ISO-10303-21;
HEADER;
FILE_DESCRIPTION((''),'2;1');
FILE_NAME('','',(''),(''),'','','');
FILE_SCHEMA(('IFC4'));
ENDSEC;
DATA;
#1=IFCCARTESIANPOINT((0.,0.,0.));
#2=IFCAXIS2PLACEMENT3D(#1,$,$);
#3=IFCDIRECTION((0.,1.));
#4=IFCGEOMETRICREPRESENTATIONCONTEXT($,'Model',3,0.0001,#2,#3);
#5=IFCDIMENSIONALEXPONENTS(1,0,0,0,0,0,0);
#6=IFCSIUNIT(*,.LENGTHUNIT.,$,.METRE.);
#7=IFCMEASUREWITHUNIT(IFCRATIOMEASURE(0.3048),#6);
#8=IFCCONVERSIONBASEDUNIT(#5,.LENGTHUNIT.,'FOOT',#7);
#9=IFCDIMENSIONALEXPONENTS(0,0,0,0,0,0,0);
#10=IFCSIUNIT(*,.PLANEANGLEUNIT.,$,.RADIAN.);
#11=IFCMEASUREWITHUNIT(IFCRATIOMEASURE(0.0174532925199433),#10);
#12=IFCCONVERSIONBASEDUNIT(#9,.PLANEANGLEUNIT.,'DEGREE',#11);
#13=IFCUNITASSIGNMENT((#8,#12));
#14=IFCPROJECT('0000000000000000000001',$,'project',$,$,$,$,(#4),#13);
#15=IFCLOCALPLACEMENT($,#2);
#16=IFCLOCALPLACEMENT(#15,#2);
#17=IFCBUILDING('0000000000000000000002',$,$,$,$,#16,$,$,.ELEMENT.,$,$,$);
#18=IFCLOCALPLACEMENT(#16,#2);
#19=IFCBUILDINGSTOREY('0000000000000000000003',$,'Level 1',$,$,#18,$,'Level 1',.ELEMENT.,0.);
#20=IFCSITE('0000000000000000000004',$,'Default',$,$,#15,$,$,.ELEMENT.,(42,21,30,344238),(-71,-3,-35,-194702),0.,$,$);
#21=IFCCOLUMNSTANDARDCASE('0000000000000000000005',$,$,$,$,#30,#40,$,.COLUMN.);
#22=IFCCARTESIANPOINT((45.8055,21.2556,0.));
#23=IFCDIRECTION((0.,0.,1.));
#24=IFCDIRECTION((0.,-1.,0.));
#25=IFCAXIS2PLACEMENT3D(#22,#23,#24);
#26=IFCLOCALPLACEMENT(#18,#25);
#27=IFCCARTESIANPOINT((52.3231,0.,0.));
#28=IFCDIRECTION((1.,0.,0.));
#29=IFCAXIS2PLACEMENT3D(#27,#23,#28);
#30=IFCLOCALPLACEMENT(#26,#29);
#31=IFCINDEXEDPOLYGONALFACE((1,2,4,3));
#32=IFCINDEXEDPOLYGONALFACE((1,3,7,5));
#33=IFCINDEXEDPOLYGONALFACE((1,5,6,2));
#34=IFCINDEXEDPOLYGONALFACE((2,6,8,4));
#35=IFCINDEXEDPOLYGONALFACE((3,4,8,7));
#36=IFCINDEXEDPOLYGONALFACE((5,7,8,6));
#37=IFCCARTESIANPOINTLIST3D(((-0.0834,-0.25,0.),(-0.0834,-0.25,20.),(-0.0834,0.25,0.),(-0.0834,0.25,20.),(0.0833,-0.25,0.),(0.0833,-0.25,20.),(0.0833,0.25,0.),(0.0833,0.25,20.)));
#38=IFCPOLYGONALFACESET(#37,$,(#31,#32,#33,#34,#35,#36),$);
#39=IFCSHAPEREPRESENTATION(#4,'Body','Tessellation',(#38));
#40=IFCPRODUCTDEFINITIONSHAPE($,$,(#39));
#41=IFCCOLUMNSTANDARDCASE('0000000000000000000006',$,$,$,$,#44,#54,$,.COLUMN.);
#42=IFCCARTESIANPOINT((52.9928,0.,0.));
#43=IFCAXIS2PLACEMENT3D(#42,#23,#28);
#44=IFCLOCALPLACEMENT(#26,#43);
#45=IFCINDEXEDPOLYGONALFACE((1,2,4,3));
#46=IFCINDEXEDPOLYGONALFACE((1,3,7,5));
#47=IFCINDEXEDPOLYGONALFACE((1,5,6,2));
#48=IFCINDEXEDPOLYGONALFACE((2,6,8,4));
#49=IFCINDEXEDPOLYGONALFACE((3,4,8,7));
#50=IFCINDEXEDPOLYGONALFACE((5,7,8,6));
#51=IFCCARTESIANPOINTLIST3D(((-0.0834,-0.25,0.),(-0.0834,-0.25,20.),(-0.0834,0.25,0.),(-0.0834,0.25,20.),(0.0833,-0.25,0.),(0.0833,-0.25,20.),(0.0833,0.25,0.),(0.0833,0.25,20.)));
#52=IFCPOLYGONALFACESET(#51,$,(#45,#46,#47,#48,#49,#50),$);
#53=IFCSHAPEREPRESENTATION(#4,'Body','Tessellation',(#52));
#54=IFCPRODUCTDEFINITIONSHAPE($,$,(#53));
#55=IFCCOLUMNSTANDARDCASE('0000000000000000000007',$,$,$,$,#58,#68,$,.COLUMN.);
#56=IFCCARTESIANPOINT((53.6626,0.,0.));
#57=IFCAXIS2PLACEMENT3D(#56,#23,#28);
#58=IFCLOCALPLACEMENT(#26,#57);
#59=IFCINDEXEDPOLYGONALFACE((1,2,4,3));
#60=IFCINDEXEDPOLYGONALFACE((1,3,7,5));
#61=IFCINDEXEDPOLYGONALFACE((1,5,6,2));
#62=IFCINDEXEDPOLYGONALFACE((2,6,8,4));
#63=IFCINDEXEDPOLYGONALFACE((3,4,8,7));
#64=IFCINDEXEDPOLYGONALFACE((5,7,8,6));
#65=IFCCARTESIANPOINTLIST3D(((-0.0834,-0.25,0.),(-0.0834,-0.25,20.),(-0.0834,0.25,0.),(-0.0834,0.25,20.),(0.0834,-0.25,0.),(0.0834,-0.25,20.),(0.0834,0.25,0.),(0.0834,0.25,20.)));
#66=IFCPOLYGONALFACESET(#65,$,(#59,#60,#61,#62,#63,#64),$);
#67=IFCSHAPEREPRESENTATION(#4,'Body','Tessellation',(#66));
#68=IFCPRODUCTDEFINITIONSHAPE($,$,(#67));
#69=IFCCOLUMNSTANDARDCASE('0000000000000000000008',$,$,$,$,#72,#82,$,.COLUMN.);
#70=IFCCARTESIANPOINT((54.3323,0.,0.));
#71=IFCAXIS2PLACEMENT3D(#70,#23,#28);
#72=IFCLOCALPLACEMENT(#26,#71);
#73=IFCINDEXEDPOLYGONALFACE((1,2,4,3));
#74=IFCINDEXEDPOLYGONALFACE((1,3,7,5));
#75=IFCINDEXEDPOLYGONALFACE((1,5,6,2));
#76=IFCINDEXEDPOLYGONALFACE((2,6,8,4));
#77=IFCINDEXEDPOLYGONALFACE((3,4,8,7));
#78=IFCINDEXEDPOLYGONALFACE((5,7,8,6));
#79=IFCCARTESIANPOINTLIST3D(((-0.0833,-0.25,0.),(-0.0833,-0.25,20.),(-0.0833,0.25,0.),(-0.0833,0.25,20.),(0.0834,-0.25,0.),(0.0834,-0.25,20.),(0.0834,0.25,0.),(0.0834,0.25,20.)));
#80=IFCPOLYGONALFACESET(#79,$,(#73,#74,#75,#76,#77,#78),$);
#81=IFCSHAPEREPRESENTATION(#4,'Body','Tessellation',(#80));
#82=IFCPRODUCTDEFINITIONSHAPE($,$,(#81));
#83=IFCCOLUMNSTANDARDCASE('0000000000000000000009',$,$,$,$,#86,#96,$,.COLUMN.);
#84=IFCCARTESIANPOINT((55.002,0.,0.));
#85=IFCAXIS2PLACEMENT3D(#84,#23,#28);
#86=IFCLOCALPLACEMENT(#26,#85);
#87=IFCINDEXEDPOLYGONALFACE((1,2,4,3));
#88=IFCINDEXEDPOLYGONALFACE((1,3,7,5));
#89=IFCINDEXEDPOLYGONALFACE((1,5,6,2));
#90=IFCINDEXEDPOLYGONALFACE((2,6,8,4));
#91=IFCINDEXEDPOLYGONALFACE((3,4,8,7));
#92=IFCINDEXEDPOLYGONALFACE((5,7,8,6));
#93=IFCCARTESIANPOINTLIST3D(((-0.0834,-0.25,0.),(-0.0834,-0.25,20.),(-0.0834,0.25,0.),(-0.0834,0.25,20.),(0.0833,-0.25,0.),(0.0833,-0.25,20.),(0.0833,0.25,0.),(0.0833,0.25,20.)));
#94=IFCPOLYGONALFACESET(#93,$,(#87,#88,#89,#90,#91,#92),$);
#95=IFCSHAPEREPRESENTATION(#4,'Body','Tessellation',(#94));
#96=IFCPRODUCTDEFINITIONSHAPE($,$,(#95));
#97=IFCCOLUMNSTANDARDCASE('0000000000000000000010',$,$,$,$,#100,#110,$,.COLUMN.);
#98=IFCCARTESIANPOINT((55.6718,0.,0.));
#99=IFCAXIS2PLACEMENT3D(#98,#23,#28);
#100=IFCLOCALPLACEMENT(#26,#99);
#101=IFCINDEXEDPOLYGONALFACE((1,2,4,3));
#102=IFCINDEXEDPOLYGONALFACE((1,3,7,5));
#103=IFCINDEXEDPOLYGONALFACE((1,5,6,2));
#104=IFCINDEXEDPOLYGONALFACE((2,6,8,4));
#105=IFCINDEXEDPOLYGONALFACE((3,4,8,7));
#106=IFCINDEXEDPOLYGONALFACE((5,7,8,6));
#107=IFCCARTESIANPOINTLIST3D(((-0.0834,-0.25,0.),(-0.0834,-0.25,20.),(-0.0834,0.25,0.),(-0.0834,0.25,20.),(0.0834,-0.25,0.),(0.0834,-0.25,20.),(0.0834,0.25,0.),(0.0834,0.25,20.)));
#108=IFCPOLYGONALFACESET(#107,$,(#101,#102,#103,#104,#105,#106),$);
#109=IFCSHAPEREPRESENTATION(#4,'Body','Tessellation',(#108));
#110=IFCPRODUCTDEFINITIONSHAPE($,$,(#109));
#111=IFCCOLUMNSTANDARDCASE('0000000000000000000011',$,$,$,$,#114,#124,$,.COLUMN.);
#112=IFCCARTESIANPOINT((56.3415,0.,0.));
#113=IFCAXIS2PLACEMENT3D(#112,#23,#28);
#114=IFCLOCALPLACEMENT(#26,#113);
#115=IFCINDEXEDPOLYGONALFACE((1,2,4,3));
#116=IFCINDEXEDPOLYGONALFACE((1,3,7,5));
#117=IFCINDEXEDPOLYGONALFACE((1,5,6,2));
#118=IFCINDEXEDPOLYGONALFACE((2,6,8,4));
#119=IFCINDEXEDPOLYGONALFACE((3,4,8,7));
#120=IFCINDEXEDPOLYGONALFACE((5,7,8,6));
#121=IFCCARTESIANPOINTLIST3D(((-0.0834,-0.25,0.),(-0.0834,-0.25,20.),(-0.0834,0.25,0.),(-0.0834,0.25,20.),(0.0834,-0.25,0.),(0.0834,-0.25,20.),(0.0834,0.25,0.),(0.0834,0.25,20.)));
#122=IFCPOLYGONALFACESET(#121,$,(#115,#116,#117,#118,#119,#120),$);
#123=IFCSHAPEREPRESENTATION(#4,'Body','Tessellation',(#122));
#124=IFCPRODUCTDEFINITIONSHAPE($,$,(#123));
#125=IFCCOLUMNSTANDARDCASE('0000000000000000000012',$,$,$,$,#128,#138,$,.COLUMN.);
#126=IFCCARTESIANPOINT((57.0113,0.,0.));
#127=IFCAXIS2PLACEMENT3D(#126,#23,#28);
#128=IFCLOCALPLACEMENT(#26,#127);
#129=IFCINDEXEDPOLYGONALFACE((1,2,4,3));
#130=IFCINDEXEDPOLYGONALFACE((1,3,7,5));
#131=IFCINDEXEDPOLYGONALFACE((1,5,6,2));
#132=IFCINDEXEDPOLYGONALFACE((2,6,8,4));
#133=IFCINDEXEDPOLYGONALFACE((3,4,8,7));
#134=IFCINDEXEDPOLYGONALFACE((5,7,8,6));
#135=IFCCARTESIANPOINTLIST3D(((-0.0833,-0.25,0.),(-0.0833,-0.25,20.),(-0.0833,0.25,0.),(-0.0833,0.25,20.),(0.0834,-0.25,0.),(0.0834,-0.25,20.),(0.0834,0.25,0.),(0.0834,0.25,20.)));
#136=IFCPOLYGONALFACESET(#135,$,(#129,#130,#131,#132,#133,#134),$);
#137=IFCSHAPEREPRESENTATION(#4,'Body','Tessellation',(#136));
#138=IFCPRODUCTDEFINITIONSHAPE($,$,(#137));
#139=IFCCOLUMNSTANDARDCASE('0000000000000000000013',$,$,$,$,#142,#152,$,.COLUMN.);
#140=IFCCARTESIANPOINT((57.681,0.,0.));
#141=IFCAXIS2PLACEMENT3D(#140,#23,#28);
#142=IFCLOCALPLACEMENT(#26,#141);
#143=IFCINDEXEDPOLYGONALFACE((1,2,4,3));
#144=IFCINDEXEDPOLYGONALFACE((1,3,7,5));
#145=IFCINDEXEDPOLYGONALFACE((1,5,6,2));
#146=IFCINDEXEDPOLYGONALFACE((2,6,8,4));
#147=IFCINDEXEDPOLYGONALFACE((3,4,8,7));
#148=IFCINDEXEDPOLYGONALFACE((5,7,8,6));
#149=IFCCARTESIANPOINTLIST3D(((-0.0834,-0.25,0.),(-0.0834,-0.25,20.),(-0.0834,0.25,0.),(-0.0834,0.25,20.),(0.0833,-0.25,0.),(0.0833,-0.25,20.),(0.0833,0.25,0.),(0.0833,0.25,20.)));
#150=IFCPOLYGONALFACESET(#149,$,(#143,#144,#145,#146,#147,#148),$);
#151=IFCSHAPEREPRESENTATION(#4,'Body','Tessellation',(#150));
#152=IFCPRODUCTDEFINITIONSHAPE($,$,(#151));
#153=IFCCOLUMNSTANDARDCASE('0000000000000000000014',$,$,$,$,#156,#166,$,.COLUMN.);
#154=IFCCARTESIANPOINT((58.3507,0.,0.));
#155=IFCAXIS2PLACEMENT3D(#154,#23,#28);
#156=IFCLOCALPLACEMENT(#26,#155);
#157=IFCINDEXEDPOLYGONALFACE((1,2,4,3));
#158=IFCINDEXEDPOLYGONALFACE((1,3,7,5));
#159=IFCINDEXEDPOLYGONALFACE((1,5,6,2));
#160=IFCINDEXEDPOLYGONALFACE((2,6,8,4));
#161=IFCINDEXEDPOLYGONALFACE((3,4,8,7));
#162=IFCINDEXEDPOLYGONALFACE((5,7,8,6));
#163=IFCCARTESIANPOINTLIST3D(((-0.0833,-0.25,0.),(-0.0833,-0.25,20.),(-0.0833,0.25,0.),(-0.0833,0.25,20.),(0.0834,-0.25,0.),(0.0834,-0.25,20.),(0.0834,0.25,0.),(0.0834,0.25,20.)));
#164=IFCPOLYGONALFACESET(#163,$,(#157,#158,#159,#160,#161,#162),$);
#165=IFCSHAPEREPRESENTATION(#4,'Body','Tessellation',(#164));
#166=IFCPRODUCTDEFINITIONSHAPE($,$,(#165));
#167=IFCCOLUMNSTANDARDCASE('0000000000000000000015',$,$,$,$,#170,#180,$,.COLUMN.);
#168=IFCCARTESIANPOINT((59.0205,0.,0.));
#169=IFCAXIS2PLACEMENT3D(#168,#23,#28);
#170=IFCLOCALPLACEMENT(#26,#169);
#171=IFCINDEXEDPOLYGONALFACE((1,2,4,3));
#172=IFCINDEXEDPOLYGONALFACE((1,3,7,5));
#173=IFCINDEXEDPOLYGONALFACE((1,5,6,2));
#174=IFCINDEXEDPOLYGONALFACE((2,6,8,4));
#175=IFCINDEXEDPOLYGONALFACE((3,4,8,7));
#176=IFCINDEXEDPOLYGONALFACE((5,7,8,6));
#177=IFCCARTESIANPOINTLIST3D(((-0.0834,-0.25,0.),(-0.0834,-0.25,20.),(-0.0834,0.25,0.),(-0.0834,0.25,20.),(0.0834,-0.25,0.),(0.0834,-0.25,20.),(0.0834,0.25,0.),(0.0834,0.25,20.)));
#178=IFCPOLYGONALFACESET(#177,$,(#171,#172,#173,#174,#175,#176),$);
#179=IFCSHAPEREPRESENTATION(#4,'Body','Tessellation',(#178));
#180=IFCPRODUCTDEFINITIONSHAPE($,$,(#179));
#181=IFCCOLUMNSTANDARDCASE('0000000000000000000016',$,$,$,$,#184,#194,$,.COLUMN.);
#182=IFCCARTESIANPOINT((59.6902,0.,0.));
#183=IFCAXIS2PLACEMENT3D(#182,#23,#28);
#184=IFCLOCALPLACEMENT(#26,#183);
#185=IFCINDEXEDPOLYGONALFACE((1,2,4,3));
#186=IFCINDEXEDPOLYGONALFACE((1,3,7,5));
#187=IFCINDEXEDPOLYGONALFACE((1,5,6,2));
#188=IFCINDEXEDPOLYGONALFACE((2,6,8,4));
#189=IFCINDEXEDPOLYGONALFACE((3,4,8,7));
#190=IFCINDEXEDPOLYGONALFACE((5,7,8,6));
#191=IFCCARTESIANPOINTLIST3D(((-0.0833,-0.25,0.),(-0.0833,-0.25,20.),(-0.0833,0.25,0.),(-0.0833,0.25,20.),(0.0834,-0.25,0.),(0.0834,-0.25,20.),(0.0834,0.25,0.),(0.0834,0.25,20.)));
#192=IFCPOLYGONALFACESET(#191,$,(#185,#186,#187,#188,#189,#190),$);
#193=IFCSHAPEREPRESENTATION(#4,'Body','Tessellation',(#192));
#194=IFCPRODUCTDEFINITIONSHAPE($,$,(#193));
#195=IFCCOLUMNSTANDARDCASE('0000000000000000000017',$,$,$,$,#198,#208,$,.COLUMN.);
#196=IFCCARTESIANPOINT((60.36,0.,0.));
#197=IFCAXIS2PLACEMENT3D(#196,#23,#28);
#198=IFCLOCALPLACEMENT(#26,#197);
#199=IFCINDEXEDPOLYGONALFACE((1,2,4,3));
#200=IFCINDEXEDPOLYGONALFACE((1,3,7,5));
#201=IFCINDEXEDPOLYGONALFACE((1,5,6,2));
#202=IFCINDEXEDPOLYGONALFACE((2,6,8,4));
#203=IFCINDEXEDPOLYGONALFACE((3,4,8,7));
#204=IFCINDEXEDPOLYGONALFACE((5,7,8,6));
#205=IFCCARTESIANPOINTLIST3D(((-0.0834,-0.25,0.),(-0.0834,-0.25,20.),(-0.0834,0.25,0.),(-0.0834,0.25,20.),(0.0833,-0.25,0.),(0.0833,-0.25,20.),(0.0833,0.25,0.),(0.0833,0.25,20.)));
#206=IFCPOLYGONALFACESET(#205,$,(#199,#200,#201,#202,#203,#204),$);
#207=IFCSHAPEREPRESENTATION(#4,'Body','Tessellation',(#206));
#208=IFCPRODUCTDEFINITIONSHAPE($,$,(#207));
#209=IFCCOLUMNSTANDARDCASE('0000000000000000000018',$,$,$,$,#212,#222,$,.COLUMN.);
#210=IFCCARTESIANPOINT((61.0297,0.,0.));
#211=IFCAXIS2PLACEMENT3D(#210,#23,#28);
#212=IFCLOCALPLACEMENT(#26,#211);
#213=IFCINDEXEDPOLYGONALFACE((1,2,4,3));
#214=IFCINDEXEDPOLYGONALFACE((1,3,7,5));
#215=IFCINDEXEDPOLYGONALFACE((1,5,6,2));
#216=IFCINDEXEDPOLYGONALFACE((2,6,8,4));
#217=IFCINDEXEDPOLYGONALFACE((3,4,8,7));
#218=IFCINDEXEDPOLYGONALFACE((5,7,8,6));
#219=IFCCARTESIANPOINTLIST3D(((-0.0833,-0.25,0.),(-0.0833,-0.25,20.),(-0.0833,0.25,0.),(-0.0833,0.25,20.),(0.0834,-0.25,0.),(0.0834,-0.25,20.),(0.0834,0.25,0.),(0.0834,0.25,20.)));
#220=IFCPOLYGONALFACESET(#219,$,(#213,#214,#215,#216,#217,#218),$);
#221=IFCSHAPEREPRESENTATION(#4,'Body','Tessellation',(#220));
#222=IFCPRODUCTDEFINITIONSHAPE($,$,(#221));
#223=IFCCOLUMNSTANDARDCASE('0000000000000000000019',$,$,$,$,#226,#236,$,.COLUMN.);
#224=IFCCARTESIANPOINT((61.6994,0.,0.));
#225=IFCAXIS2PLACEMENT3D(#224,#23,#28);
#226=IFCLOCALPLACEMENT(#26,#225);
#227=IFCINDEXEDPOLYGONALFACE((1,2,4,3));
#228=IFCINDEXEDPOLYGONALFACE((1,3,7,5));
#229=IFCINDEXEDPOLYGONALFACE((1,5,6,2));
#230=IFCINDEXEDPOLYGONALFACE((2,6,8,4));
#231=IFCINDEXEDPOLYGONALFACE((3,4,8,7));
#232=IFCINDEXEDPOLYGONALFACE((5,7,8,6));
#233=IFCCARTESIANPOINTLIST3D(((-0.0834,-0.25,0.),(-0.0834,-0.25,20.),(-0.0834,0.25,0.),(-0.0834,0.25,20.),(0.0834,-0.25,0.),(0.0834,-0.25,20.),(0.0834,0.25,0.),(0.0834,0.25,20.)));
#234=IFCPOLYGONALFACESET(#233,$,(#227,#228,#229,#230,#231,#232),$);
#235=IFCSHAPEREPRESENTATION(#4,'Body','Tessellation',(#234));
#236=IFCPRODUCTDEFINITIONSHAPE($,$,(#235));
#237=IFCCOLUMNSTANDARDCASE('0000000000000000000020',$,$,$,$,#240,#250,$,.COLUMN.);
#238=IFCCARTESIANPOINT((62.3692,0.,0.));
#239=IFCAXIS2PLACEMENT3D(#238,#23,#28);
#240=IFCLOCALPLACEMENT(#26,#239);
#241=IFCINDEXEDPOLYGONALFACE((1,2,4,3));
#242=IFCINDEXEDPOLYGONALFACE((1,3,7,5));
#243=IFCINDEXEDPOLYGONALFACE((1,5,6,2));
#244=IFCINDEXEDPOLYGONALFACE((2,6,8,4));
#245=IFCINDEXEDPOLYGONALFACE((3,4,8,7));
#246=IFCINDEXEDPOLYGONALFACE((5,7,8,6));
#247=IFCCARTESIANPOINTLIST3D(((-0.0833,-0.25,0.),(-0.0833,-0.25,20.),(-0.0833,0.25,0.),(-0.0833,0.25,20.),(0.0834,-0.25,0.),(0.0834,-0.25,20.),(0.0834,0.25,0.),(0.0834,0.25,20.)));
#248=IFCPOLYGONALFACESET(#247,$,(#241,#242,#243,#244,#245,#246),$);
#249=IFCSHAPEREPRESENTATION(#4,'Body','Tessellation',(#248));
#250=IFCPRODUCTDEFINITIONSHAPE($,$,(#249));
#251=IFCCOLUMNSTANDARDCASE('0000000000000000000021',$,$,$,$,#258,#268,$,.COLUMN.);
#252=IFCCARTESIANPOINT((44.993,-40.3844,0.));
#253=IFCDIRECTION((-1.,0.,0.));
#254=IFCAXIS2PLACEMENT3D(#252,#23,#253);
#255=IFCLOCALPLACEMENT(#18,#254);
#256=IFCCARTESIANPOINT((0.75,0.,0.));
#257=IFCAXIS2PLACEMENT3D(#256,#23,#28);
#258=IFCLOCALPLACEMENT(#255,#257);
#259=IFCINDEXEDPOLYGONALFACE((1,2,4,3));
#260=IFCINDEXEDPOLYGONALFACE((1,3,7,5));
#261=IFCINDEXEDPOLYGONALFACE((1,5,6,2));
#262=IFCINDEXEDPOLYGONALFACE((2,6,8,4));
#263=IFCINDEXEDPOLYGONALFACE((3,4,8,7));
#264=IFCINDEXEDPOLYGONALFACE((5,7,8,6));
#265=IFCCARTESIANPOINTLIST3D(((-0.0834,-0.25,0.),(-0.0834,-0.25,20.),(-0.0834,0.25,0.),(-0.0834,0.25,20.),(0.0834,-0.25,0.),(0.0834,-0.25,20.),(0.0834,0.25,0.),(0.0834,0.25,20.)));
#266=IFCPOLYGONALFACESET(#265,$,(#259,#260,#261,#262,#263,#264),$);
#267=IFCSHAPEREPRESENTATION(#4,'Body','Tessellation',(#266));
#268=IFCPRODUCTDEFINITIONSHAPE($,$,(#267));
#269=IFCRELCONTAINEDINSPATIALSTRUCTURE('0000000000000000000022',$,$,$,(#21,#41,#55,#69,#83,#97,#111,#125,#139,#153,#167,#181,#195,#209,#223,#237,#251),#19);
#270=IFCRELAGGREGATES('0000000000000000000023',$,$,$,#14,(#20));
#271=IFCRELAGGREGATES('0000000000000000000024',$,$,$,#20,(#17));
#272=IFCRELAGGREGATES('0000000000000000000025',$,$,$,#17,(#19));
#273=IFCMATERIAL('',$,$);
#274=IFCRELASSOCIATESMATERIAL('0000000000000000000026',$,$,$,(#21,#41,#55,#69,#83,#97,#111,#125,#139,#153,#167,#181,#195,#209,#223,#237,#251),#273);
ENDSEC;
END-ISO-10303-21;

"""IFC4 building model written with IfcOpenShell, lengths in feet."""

from ifc_helpers import new_model, entity, si_unit, converted_unit, direction, frame, origin, place, context, project, spatial, rectangle, extrude, material, element, save


model = new_model("IFC4")

# Units and contexts
model_context = context("Model", 3, precision=0.0001, world=origin(), true_north=direction((0.0, 1.0)))
ifc_project = project(units=[converted_unit("LENGTHUNIT", "FOOT", entity("IfcRatioMeasure", 0.3048), si_unit("LENGTHUNIT", "METRE"), dimensions=[1, 0, 0, 0, 0, 0, 0]), converted_unit("PLANEANGLEUNIT", "DEGREE", entity("IfcRatioMeasure", 0.0174532925199433), si_unit("PLANEANGLEUNIT", "RADIAN"), dimensions=[0, 0, 0, 0, 0, 0, 0])], contexts=[model_context])

# Site, building, storey
site_placement = place(None, origin())
site = spatial("IfcSite", under=ifc_project, at=site_placement, Name="Default", CompositionType="ELEMENT", RefLatitude=(42, 21, 30, 344238), RefLongitude=(-71, -3, -35, -194702), RefElevation=0.0)
building_placement = place(site_placement, origin())
building = spatial("IfcBuilding", under=site, at=building_placement, CompositionType="ELEMENT")
storey_placement = place(building_placement, origin())
storey = spatial("IfcBuildingStorey", under=building, at=storey_placement, Name="Level 1", LongName="Level 1", CompositionType="ELEMENT", Elevation=0.0)

# Columns
ifc_material_1 = material(Name="")
placement = place(storey_placement, frame((45.8055, 21.2556, 0.0), z_axis=(0.0, 0.0, 1.0), x_axis=(0.0, -1.0, 0.0)))
for number, where, z_axis, x_axis in (
    (1, (52.3231, 0.0, 0.0), (0.0, 0.0, 1.0), (1.0, 0.0, 0.0)),
    (2, (52.9928, 0.0, 0.0), (0.0, 0.0, 1.0), (1.0, 0.0, 0.0)),
    (3, (53.6626, 0.0, 0.0), (0.0, 0.0, 1.0), (1.0, 0.0, 0.0)),
    (4, (54.3323, 0.0, 0.0), (0.0, 0.0, 1.0), (1.0, 0.0, 0.0)),
    (5, (55.002, 0.0, 0.0), (0.0, 0.0, 1.0), (1.0, 0.0, 0.0)),
    (6, (55.6718, 0.0, 0.0), (0.0, 0.0, 1.0), (1.0, 0.0, 0.0)),
    (7, (56.3415, 0.0, 0.0), (0.0, 0.0, 1.0), (1.0, 0.0, 0.0)),
    (8, (57.0113, 0.0, 0.0), (0.0, 0.0, 1.0), (1.0, 0.0, 0.0)),
    (9, (57.681, 0.0, 0.0), (0.0, 0.0, 1.0), (1.0, 0.0, 0.0)),
    (10, (58.3507, 0.0, 0.0), (0.0, 0.0, 1.0), (1.0, 0.0, 0.0)),
    (11, (59.0205, 0.0, 0.0), (0.0, 0.0, 1.0), (1.0, 0.0, 0.0)),
    (12, (59.6902, 0.0, 0.0), (0.0, 0.0, 1.0), (1.0, 0.0, 0.0)),
    (13, (60.36, 0.0, 0.0), (0.0, 0.0, 1.0), (1.0, 0.0, 0.0)),
    (14, (61.0297, 0.0, 0.0), (0.0, 0.0, 1.0), (1.0, 0.0, 0.0)),
    (15, (61.6994, 0.0, 0.0), (0.0, 0.0, 1.0), (1.0, 0.0, 0.0)),
    (16, (62.3692, 0.0, 0.0), (0.0, 0.0, 1.0), (1.0, 0.0, 0.0)),
):
    element("IfcColumnStandardCase", number, at=place(placement, frame(where, z_axis=z_axis, x_axis=x_axis)), inside=storey, material=ifc_material_1, PredefinedType="COLUMN", context=model_context, shape_type="SweptSolid", body=[
        extrude(rectangle(XDim=0.1667, YDim=0.5), origin(), (0.0, 0.0, 1.0), 20.0),
    ])
wall_placement = place(storey_placement, frame((44.993, -40.3844, 0.0), z_axis=(0.0, 0.0, 1.0), x_axis=(-1.0, 0.0, 0.0)))
for number, where, z_axis, x_axis in (
    (17, (0.75, 0.0, 0.0), (0.0, 0.0, 1.0), (1.0, 0.0, 0.0)),
):
    element("IfcColumnStandardCase", number, at=place(wall_placement, frame(where, z_axis=z_axis, x_axis=x_axis)), inside=storey, material=ifc_material_1, PredefinedType="COLUMN", context=model_context, shape_type="SweptSolid", body=[
        extrude(rectangle(XDim=0.1667, YDim=0.5), origin(), (0.0, 0.0, 1.0), 20.0),
    ])

save(model, "model.ifc")
